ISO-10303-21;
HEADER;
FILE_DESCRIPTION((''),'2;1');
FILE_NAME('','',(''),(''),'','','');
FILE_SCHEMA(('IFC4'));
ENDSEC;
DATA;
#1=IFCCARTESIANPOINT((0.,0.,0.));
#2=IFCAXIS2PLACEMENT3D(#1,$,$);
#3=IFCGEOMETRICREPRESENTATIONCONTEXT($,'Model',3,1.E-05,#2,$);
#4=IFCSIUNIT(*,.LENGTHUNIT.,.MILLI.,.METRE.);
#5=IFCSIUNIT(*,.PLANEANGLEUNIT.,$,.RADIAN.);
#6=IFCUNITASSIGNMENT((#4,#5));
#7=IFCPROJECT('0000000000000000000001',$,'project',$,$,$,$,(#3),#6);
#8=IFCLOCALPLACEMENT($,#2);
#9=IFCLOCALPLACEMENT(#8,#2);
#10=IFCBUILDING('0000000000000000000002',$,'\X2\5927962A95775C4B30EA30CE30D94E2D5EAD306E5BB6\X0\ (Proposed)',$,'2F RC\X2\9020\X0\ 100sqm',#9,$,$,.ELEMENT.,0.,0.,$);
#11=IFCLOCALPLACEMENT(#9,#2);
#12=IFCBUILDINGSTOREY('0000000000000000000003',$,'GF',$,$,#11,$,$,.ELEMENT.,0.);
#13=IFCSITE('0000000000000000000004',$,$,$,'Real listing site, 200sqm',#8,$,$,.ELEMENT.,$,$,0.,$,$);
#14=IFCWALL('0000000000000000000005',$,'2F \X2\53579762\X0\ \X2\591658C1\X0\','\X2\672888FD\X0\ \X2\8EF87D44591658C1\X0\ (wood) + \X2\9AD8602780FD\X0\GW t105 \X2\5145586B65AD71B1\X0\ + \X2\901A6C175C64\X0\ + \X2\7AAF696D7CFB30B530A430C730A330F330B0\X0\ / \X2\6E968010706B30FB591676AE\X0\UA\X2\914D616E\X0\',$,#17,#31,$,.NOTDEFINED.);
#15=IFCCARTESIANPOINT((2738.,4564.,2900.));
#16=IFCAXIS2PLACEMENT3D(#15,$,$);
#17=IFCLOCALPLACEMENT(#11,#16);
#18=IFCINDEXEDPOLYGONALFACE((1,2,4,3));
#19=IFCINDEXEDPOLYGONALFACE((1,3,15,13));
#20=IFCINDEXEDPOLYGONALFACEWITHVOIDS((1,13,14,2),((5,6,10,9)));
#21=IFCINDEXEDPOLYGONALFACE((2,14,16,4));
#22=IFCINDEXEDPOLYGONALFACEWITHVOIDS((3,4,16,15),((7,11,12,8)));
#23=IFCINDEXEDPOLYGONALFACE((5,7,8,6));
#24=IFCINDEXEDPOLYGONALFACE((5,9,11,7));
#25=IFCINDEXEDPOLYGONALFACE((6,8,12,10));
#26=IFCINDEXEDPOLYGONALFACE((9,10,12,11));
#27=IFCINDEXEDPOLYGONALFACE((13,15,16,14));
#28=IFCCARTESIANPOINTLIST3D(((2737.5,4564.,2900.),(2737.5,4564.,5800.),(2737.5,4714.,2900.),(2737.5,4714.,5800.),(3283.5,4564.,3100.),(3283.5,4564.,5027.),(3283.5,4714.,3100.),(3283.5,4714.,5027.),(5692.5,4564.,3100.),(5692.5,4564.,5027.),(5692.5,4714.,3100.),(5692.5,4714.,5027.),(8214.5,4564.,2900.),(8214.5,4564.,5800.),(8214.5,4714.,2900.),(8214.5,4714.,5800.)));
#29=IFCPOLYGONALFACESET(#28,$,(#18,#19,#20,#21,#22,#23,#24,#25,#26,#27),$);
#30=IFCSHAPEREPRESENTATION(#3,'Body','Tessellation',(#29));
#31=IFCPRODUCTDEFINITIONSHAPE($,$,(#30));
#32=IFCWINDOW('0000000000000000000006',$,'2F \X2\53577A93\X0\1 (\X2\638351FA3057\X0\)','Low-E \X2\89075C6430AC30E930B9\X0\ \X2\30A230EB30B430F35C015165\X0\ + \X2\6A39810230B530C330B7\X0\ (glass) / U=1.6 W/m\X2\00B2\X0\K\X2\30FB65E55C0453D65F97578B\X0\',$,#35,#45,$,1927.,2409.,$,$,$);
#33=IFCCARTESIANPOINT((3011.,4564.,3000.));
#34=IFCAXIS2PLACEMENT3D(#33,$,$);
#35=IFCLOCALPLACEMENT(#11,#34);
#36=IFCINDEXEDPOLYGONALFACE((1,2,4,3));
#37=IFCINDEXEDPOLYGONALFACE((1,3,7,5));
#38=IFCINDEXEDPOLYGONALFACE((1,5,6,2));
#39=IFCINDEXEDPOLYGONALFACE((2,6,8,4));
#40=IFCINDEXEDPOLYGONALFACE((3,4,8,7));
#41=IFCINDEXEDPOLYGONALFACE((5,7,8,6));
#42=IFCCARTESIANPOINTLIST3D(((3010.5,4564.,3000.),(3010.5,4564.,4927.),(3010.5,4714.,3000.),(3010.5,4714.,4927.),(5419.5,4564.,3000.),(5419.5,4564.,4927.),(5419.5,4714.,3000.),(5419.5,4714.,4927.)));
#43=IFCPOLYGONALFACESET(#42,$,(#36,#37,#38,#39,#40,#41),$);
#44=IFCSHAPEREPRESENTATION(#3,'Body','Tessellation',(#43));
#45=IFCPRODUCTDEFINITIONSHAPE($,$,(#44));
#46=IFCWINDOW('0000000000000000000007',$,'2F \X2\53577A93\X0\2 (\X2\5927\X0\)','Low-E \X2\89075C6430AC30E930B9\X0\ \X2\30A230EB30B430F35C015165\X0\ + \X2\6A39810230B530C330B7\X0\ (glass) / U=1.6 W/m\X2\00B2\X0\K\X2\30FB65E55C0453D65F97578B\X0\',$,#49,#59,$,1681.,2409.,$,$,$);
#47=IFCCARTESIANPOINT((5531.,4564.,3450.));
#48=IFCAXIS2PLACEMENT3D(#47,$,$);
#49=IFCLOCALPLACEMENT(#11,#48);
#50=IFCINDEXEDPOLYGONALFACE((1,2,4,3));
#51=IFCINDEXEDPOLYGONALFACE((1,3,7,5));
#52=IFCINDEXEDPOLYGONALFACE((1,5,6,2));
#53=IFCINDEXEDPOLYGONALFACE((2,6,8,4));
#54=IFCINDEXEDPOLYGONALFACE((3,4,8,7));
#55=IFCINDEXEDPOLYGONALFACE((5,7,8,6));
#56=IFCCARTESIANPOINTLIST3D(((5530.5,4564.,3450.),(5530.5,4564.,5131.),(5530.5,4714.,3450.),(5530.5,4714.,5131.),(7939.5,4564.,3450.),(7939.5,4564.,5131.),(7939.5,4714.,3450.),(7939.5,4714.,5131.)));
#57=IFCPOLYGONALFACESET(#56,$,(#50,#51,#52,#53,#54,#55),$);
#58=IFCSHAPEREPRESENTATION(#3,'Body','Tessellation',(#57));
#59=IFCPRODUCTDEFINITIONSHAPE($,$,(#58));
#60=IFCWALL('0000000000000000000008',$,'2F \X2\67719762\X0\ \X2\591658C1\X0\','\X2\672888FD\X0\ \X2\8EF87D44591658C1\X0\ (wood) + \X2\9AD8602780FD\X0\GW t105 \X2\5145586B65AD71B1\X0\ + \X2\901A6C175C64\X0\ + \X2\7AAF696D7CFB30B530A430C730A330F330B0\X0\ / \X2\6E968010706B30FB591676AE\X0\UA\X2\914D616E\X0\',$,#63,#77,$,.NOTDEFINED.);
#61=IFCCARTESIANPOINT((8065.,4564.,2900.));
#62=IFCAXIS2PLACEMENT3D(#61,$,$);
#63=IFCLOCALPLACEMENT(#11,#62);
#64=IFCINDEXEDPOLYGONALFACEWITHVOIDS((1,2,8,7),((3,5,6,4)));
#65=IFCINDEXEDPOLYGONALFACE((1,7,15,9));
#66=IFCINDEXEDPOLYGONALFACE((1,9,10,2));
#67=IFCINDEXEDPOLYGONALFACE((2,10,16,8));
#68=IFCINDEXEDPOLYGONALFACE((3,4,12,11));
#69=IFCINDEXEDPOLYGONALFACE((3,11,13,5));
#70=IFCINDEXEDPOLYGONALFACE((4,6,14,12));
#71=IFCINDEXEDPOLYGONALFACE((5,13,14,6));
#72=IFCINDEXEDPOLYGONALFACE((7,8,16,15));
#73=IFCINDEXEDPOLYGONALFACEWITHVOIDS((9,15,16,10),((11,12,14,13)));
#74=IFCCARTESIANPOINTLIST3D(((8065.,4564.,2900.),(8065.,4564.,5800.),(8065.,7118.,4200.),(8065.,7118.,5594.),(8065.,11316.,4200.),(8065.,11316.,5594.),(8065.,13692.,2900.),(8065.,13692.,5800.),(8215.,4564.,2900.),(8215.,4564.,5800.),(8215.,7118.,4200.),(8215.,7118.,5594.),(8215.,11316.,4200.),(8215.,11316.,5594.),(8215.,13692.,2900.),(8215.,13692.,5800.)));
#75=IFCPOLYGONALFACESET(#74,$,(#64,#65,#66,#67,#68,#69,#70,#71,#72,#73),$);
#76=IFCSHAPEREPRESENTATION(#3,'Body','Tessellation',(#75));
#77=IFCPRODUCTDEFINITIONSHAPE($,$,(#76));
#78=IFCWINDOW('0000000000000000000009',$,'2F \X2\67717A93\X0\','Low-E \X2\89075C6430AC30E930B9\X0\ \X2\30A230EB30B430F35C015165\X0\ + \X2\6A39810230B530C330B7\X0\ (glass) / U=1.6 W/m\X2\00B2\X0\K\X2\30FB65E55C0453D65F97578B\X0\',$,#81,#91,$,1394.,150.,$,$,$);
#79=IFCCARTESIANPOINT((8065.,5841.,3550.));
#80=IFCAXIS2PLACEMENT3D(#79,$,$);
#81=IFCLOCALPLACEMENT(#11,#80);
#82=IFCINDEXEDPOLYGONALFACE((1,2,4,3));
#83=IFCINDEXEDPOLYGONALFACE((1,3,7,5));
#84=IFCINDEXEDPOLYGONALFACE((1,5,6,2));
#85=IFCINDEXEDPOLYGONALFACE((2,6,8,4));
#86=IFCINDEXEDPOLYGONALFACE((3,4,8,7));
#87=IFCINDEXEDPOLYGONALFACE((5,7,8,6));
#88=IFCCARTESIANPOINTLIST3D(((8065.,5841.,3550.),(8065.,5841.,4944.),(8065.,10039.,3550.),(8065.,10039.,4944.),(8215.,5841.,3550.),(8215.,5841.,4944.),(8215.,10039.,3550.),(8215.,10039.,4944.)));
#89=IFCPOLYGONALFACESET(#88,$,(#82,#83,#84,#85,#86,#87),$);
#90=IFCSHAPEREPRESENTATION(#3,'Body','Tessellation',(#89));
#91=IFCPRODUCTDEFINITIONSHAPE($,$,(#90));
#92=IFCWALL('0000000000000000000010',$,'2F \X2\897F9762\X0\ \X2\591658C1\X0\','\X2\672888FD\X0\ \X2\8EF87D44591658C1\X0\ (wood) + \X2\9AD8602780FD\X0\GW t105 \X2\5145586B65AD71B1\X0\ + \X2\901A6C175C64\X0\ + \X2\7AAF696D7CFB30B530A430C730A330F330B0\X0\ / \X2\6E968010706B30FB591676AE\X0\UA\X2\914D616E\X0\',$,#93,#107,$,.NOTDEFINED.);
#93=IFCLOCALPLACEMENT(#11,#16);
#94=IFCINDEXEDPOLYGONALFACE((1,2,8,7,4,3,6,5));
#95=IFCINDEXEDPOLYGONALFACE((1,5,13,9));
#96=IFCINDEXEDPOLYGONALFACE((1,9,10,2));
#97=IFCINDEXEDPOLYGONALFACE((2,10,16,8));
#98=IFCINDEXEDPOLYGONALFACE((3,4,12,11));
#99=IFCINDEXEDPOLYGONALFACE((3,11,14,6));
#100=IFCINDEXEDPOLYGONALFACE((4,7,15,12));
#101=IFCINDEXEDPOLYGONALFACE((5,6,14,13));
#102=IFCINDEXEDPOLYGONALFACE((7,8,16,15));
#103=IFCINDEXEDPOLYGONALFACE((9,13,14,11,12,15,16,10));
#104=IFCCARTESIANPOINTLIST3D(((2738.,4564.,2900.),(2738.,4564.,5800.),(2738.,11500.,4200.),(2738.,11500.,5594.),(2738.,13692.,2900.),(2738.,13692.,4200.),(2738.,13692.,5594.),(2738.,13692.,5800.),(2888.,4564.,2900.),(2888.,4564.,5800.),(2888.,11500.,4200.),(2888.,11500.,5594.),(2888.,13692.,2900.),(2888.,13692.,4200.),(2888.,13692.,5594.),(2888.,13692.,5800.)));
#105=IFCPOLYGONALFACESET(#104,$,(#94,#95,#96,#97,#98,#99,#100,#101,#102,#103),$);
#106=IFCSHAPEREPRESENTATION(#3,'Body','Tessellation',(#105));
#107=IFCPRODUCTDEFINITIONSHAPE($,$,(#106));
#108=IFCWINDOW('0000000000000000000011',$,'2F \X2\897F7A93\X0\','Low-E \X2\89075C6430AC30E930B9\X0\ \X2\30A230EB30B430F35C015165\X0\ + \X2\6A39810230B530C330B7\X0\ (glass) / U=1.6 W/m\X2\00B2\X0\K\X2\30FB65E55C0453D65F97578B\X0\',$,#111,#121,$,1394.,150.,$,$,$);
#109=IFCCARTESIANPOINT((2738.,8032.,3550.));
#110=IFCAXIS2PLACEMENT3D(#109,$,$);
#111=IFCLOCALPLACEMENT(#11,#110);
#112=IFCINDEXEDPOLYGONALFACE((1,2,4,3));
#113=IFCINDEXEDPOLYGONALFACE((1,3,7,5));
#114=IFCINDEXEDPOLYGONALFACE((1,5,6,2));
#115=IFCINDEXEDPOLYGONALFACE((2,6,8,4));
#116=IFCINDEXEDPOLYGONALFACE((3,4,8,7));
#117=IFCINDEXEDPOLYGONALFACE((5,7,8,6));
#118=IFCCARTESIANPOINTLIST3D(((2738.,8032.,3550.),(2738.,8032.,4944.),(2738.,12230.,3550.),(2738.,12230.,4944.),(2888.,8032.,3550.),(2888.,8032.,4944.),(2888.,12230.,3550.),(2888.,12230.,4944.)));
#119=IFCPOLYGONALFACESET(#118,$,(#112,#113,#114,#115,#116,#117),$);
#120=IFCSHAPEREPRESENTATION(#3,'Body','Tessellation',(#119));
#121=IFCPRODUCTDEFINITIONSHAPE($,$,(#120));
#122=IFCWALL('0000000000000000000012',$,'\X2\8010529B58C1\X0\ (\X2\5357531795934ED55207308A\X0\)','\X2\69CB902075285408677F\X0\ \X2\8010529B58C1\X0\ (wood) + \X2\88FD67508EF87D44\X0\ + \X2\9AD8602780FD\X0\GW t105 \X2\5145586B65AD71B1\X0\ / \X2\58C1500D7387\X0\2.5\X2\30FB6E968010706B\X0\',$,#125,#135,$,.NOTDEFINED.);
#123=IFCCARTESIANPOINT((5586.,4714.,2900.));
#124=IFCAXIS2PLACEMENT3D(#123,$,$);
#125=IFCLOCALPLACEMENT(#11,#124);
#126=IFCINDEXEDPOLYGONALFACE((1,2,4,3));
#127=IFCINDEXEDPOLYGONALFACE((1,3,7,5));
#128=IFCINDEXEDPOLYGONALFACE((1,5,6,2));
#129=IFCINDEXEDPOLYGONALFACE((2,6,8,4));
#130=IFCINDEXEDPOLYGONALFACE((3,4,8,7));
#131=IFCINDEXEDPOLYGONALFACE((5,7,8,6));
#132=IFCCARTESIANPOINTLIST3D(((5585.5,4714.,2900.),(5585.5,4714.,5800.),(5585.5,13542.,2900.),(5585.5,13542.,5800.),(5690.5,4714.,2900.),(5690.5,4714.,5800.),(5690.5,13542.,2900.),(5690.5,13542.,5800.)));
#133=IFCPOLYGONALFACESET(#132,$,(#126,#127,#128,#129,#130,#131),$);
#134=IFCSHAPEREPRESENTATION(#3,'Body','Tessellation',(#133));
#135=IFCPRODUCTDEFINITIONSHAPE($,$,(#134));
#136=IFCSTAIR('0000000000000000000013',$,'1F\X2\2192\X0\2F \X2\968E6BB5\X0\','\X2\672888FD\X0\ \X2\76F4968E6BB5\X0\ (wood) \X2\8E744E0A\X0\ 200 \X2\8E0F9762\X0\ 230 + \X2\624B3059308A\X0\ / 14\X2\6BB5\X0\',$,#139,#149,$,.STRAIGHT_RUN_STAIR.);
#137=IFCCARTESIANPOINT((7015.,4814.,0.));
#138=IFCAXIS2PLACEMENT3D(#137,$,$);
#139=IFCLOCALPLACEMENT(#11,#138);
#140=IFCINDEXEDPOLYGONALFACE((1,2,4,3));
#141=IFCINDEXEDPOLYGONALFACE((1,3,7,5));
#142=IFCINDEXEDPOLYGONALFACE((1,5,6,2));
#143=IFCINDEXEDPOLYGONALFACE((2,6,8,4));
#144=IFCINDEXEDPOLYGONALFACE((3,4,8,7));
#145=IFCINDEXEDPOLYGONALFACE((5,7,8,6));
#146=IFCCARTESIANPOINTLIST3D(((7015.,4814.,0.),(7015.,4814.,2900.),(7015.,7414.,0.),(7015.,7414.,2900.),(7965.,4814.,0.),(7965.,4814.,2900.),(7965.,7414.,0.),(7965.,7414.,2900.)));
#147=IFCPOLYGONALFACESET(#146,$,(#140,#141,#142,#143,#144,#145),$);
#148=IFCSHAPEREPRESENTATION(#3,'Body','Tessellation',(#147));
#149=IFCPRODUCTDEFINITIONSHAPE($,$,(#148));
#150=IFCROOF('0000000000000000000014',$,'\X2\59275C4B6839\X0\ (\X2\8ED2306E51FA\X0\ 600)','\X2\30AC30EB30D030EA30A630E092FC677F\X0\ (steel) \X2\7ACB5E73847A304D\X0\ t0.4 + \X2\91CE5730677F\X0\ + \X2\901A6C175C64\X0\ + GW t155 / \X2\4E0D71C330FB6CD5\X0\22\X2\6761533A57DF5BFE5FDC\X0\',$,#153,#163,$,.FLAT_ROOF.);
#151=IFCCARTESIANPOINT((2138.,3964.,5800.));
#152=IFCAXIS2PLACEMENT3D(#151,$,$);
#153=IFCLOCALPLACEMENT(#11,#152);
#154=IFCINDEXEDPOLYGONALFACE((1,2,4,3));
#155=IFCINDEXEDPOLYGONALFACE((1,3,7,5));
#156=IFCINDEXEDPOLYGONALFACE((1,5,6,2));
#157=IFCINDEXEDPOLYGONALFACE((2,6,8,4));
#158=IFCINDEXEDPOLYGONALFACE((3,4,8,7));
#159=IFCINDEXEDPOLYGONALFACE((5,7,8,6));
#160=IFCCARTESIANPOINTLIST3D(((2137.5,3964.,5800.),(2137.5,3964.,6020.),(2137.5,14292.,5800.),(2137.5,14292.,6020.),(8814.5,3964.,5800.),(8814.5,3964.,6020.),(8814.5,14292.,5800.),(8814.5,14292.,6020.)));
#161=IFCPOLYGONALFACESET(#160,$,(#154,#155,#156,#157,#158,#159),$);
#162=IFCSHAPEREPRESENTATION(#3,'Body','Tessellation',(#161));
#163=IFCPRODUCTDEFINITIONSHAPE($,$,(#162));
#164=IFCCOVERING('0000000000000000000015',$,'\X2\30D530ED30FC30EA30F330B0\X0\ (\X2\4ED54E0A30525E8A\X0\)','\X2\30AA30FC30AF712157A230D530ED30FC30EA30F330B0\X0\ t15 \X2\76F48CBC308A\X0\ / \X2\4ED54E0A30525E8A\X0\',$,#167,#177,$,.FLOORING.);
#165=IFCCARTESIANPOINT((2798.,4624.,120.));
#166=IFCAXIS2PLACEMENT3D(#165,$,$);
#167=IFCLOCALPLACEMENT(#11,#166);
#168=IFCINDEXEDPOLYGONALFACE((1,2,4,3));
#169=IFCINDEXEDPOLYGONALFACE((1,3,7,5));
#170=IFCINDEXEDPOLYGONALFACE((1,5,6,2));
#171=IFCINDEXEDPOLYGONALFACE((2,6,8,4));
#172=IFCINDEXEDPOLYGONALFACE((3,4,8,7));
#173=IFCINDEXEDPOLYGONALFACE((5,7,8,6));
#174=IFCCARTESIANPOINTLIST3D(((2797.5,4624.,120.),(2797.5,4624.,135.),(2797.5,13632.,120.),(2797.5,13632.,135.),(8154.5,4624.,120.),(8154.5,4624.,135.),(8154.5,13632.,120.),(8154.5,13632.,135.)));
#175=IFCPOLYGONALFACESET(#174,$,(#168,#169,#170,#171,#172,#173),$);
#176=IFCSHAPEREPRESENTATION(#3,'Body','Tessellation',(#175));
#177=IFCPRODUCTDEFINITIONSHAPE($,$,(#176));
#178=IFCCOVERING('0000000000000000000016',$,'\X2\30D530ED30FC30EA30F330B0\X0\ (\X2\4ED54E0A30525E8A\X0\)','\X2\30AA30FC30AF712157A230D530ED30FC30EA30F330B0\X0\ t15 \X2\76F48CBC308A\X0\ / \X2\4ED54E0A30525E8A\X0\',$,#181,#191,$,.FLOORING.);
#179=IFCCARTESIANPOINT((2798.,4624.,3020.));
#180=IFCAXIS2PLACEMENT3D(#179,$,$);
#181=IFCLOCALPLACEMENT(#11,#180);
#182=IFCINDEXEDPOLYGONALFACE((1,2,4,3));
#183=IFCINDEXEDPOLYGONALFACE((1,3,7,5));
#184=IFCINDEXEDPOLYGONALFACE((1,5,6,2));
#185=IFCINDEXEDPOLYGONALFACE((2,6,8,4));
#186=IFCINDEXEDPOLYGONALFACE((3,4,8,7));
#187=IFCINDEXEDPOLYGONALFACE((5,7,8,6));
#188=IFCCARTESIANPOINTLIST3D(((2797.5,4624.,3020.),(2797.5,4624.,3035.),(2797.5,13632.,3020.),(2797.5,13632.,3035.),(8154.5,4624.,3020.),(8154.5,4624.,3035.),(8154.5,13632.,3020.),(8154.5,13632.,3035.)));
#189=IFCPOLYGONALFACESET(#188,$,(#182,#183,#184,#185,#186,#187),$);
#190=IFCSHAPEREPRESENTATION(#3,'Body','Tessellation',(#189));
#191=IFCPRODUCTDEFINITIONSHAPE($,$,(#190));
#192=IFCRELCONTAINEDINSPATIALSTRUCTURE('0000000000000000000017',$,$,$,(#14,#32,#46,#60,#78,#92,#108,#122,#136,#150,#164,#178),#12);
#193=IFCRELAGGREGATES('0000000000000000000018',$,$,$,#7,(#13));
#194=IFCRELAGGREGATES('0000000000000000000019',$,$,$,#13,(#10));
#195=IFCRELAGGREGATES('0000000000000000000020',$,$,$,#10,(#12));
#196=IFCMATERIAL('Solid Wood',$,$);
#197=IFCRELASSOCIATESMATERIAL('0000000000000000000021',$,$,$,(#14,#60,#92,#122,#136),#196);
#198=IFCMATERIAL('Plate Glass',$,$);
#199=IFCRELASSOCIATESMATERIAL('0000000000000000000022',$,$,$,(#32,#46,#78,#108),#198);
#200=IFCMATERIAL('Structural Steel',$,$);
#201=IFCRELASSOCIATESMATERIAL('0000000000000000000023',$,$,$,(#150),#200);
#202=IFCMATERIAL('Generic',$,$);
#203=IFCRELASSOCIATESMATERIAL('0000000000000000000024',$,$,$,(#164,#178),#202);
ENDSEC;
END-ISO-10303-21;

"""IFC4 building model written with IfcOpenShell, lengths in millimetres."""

from ifc_helpers import new_model, si_unit, frame, frame_2d, origin, place, context, project, spatial, rectangle, extrude, material, element, fill, save


model = new_model("IFC4")

# Units and contexts
model_context = context("Model", 3, precision=1e-05, world=origin())
ifc_project = project(units=[si_unit("LENGTHUNIT", "METRE", prefix="MILLI"), si_unit("PLANEANGLEUNIT", "RADIAN")], contexts=[model_context])

# Site, building, storey
site_placement = place(None, origin())
site = spatial("IfcSite", under=ifc_project, at=site_placement, ObjectType="Real listing site, 200sqm", CompositionType="ELEMENT", RefElevation=0.0)
building_placement = place(site_placement, origin())
building = spatial("IfcBuilding", under=site, at=building_placement, Name="大阪長屋リノベ中庭の家 (Proposed)", ObjectType="2F RC造 100sqm", CompositionType="ELEMENT", ElevationOfRefHeight=0.0, ElevationOfTerrain=0.0)
storey_placement = place(building_placement, origin())
storey = spatial("IfcBuildingStorey", under=building, at=storey_placement, Name="GF", CompositionType="ELEMENT", Elevation=0.0)

# Shared definitions
ifc_material_1 = material(Name="Solid Wood")

# Shared definitions
ifc_material_2 = material(Name="Plate Glass")

# Wall, openings, windows
wall_1_placement = place(storey_placement, frame((2738.0, 4564.0, 2900.0)))
wall_1 = element("IfcWall", 1, at=wall_1_placement, inside=storey, material=ifc_material_1, Name="2F 南面 外壁", Description="木製 軸組外壁 (wood) + 高性能GW t105 充填断熱 + 通気層 + 窯業系サイディング / 準耐火・外皮UA配慮", PredefinedType="NOTDEFINED", context=model_context, shape_type="SweptSolid", body=[
    extrude(rectangle(XDim=5477.0, YDim=150.0, at=frame_2d((2738.0, 75.0))), frame((2738.0, 4564.0, 2900.0)), (0.0, 0.0, 1.0), 2900.0),
])
opening_1_placement = place(storey_placement, frame((3011.0, 4564.0, 3000.0)))
opening_1 = element("IfcOpeningElement", 2, at=opening_1_placement, cuts=wall_1, PredefinedType="NOTDEFINED", context=model_context, shape_type="SweptSolid", body=[
    extrude(rectangle(XDim=2409.0, YDim=150.0, at=frame_2d((1204.0, 75.0))), frame((3011.0, 4564.0, 3000.0)), (0.0, 0.0, 1.0), 1927.0),
])
opening_2_placement = place(storey_placement, frame((5531.0, 4564.0, 3450.0)))
opening_2 = element("IfcOpeningElement", 3, at=opening_2_placement, cuts=wall_1, PredefinedType="NOTDEFINED", context=model_context, shape_type="SweptSolid", body=[
    extrude(rectangle(XDim=2409.0, YDim=150.0, at=frame_2d((1204.0, 75.0))), frame((5531.0, 4564.0, 3450.0)), (0.0, 0.0, 1.0), 1681.0),
])
window_1_placement = place(storey_placement, frame((3011.0, 4564.0, 3000.0)))
window_1 = element("IfcWindow", 4, at=window_1_placement, inside=storey, material=ifc_material_2, Name="2F 南窓1 (掃出し)", Description="Low-E 複層ガラス アルゴン封入 + 樹脂サッシ (glass) / U=1.6 W/m²K・日射取得型", OverallHeight=1927.0, OverallWidth=2409.0, context=model_context, shape_type="SweptSolid", body=[
    extrude(rectangle(XDim=2409.0, YDim=150.0, at=frame_2d((1204.0, 75.0))), frame((3011.0, 4564.0, 3000.0)), (0.0, 0.0, 1.0), 1927.0),
])
fill(opening_1, window_1)
window_2_placement = place(storey_placement, frame((5531.0, 4564.0, 3450.0)))
window_2 = element("IfcWindow", 5, at=window_2_placement, inside=storey, material=ifc_material_2, Name="2F 南窓2 (大)", Description="Low-E 複層ガラス アルゴン封入 + 樹脂サッシ (glass) / U=1.6 W/m²K・日射取得型", OverallHeight=1681.0, OverallWidth=2409.0, context=model_context, shape_type="SweptSolid", body=[
    extrude(rectangle(XDim=2409.0, YDim=150.0, at=frame_2d((1204.0, 75.0))), frame((5531.0, 4564.0, 3450.0)), (0.0, 0.0, 1.0), 1681.0),
])
fill(opening_2, window_2)

# Walls, openings, windows
wall_2_placement = place(storey_placement, frame((8065.0, 4564.0, 2900.0)))
wall_2 = element("IfcWall", 6, at=wall_2_placement, inside=storey, material=ifc_material_1, Name="2F 東面 外壁", Description="木製 軸組外壁 (wood) + 高性能GW t105 充填断熱 + 通気層 + 窯業系サイディング / 準耐火・外皮UA配慮", PredefinedType="NOTDEFINED", context=model_context, shape_type="SweptSolid", body=[
    extrude(rectangle(XDim=150.0, YDim=9128.0, at=frame_2d((75.0, 4564.0))), frame((8065.0, 4564.0, 2900.0)), (0.0, 0.0, 1.0), 2900.0),
])
opening_3_placement = place(storey_placement, frame((8065.0, 5841.0, 3550.0)))
opening_3 = element("IfcOpeningElement", 7, at=opening_3_placement, cuts=wall_2, PredefinedType="NOTDEFINED", context=model_context, shape_type="SweptSolid", body=[
    extrude(rectangle(XDim=150.0, YDim=4198.0, at=frame_2d((75.0, 2099.0))), frame((8065.0, 5841.0, 3550.0)), (0.0, 0.0, 1.0), 1394.0),
])
window_3_placement = place(storey_placement, frame((8065.0, 5841.0, 3550.0)))
window_3 = element("IfcWindow", 8, at=window_3_placement, inside=storey, material=ifc_material_2, Name="2F 東窓", Description="Low-E 複層ガラス アルゴン封入 + 樹脂サッシ (glass) / U=1.6 W/m²K・日射取得型", OverallHeight=1394.0, OverallWidth=150.0, context=model_context, shape_type="SweptSolid", body=[
    extrude(rectangle(XDim=150.0, YDim=4198.0, at=frame_2d((75.0, 2099.0))), frame((8065.0, 5841.0, 3550.0)), (0.0, 0.0, 1.0), 1394.0),
])
fill(opening_3, window_3)
wall_3_placement = place(storey_placement, frame((2738.0, 4564.0, 2900.0)))
wall_3 = element("IfcWall", 9, at=wall_3_placement, inside=storey, material=ifc_material_1, Name="2F 西面 外壁", Description="木製 軸組外壁 (wood) + 高性能GW t105 充填断熱 + 通気層 + 窯業系サイディング / 準耐火・外皮UA配慮", PredefinedType="NOTDEFINED", context=model_context, shape_type="SweptSolid", body=[
    extrude(rectangle(XDim=150.0, YDim=9128.0, at=frame_2d((75.0, 4564.0))), frame((2738.0, 4564.0, 2900.0)), (0.0, 0.0, 1.0), 2900.0),
])
opening_4_placement = place(storey_placement, frame((2738.0, 8032.0, 3550.0)))
opening_4 = element("IfcOpeningElement", 10, at=opening_4_placement, cuts=wall_3, PredefinedType="NOTDEFINED", context=model_context, shape_type="SweptSolid", body=[
    extrude(rectangle(XDim=150.0, YDim=4198.0, at=frame_2d((75.0, 2099.0))), frame((2738.0, 8032.0, 3550.0)), (0.0, 0.0, 1.0), 1394.0),
])
window_4_placement = place(storey_placement, frame((2738.0, 8032.0, 3550.0)))
window_4 = element("IfcWindow", 11, at=window_4_placement, inside=storey, material=ifc_material_2, Name="2F 西窓", Description="Low-E 複層ガラス アルゴン封入 + 樹脂サッシ (glass) / U=1.6 W/m²K・日射取得型", OverallHeight=1394.0, OverallWidth=150.0, context=model_context, shape_type="SweptSolid", body=[
    extrude(rectangle(XDim=150.0, YDim=4198.0, at=frame_2d((75.0, 2099.0))), frame((2738.0, 8032.0, 3550.0)), (0.0, 0.0, 1.0), 1394.0),
])
fill(opening_4, window_4)

# Wall
wall_4_placement = place(storey_placement, frame((5586.0, 4714.0, 2900.0)))
element("IfcWall", 12, at=wall_4_placement, inside=storey, material=ifc_material_1, Name="耐力壁 (南北間仕切り)", Description="構造用合板 耐力壁 (wood) + 製材軸組 + 高性能GW t105 充填断熱 / 壁倍率2.5・準耐火", PredefinedType="NOTDEFINED", context=model_context, shape_type="SweptSolid", body=[
    extrude(rectangle(XDim=105.0, YDim=8828.0, at=frame_2d((52.0, 4414.0))), frame((5586.0, 4714.0, 2900.0)), (0.0, 0.0, 1.0), 2900.0),
])

# Stair
stair_placement = place(storey_placement, frame((7015.0, 4814.0, 0.0)))
element("IfcStair", 13, at=stair_placement, inside=storey, material=ifc_material_1, Name="1F→2F 階段", Description="木製 直階段 (wood) 蹴上 200 踏面 230 + 手すり / 14段", PredefinedType="STRAIGHT_RUN_STAIR", context=model_context, shape_type="SweptSolid", body=[
    extrude(rectangle(XDim=950.0, YDim=2600.0, at=frame_2d((475.0, 1300.0))), frame((7015.0, 4814.0, 0.0)), (0.0, 0.0, 1.0), 2900.0),
])

# Roof
ifc_material_3 = material(Name="Structural Steel")
roof_placement = place(storey_placement, frame((2138.0, 3964.0, 5800.0)))
element("IfcRoof", 14, at=roof_placement, inside=storey, material=ifc_material_3, Name="大屋根 (軒の出 600)", Description="ガルバリウム鋼板 (steel) 立平葺き t0.4 + 野地板 + 通気層 + GW t155 / 不燃・法22条区域対応", PredefinedType="FLAT_ROOF", context=model_context, shape_type="SweptSolid", body=[
    extrude(rectangle(XDim=6677.0, YDim=10328.0, at=frame_2d((3338.0, 5164.0))), frame((2138.0, 3964.0, 5800.0)), (0.0, 0.0, 1.0), 220.0),
])

# Coverings
ifc_material_4 = material(Name="Generic")
covering_1_placement = place(storey_placement, frame((2798.0, 4624.0, 120.0)))
element("IfcCovering", 15, at=covering_1_placement, inside=storey, material=ifc_material_4, Name="フローリング (仕上げ床)", Description="オーク無垢フローリング t15 直貼り / 仕上げ床", PredefinedType="FLOORING", context=model_context, shape_type="SweptSolid", body=[
    extrude(rectangle(XDim=5357.0, YDim=9008.0, at=frame_2d((2678.0, 4504.0))), frame((2798.0, 4624.0, 120.0)), (0.0, 0.0, 1.0), 15.0),
])
covering_2_placement = place(storey_placement, frame((2798.0, 4624.0, 3020.0)))
element("IfcCovering", 16, at=covering_2_placement, inside=storey, material=ifc_material_4, Name="フローリング (仕上げ床)", Description="オーク無垢フローリング t15 直貼り / 仕上げ床", PredefinedType="FLOORING", context=model_context, shape_type="SweptSolid", body=[
    extrude(rectangle(XDim=5357.0, YDim=9008.0, at=frame_2d((2678.0, 4504.0))), frame((2798.0, 4624.0, 3020.0)), (0.0, 0.0, 1.0), 15.0),
])

save(model, "model.ifc")
